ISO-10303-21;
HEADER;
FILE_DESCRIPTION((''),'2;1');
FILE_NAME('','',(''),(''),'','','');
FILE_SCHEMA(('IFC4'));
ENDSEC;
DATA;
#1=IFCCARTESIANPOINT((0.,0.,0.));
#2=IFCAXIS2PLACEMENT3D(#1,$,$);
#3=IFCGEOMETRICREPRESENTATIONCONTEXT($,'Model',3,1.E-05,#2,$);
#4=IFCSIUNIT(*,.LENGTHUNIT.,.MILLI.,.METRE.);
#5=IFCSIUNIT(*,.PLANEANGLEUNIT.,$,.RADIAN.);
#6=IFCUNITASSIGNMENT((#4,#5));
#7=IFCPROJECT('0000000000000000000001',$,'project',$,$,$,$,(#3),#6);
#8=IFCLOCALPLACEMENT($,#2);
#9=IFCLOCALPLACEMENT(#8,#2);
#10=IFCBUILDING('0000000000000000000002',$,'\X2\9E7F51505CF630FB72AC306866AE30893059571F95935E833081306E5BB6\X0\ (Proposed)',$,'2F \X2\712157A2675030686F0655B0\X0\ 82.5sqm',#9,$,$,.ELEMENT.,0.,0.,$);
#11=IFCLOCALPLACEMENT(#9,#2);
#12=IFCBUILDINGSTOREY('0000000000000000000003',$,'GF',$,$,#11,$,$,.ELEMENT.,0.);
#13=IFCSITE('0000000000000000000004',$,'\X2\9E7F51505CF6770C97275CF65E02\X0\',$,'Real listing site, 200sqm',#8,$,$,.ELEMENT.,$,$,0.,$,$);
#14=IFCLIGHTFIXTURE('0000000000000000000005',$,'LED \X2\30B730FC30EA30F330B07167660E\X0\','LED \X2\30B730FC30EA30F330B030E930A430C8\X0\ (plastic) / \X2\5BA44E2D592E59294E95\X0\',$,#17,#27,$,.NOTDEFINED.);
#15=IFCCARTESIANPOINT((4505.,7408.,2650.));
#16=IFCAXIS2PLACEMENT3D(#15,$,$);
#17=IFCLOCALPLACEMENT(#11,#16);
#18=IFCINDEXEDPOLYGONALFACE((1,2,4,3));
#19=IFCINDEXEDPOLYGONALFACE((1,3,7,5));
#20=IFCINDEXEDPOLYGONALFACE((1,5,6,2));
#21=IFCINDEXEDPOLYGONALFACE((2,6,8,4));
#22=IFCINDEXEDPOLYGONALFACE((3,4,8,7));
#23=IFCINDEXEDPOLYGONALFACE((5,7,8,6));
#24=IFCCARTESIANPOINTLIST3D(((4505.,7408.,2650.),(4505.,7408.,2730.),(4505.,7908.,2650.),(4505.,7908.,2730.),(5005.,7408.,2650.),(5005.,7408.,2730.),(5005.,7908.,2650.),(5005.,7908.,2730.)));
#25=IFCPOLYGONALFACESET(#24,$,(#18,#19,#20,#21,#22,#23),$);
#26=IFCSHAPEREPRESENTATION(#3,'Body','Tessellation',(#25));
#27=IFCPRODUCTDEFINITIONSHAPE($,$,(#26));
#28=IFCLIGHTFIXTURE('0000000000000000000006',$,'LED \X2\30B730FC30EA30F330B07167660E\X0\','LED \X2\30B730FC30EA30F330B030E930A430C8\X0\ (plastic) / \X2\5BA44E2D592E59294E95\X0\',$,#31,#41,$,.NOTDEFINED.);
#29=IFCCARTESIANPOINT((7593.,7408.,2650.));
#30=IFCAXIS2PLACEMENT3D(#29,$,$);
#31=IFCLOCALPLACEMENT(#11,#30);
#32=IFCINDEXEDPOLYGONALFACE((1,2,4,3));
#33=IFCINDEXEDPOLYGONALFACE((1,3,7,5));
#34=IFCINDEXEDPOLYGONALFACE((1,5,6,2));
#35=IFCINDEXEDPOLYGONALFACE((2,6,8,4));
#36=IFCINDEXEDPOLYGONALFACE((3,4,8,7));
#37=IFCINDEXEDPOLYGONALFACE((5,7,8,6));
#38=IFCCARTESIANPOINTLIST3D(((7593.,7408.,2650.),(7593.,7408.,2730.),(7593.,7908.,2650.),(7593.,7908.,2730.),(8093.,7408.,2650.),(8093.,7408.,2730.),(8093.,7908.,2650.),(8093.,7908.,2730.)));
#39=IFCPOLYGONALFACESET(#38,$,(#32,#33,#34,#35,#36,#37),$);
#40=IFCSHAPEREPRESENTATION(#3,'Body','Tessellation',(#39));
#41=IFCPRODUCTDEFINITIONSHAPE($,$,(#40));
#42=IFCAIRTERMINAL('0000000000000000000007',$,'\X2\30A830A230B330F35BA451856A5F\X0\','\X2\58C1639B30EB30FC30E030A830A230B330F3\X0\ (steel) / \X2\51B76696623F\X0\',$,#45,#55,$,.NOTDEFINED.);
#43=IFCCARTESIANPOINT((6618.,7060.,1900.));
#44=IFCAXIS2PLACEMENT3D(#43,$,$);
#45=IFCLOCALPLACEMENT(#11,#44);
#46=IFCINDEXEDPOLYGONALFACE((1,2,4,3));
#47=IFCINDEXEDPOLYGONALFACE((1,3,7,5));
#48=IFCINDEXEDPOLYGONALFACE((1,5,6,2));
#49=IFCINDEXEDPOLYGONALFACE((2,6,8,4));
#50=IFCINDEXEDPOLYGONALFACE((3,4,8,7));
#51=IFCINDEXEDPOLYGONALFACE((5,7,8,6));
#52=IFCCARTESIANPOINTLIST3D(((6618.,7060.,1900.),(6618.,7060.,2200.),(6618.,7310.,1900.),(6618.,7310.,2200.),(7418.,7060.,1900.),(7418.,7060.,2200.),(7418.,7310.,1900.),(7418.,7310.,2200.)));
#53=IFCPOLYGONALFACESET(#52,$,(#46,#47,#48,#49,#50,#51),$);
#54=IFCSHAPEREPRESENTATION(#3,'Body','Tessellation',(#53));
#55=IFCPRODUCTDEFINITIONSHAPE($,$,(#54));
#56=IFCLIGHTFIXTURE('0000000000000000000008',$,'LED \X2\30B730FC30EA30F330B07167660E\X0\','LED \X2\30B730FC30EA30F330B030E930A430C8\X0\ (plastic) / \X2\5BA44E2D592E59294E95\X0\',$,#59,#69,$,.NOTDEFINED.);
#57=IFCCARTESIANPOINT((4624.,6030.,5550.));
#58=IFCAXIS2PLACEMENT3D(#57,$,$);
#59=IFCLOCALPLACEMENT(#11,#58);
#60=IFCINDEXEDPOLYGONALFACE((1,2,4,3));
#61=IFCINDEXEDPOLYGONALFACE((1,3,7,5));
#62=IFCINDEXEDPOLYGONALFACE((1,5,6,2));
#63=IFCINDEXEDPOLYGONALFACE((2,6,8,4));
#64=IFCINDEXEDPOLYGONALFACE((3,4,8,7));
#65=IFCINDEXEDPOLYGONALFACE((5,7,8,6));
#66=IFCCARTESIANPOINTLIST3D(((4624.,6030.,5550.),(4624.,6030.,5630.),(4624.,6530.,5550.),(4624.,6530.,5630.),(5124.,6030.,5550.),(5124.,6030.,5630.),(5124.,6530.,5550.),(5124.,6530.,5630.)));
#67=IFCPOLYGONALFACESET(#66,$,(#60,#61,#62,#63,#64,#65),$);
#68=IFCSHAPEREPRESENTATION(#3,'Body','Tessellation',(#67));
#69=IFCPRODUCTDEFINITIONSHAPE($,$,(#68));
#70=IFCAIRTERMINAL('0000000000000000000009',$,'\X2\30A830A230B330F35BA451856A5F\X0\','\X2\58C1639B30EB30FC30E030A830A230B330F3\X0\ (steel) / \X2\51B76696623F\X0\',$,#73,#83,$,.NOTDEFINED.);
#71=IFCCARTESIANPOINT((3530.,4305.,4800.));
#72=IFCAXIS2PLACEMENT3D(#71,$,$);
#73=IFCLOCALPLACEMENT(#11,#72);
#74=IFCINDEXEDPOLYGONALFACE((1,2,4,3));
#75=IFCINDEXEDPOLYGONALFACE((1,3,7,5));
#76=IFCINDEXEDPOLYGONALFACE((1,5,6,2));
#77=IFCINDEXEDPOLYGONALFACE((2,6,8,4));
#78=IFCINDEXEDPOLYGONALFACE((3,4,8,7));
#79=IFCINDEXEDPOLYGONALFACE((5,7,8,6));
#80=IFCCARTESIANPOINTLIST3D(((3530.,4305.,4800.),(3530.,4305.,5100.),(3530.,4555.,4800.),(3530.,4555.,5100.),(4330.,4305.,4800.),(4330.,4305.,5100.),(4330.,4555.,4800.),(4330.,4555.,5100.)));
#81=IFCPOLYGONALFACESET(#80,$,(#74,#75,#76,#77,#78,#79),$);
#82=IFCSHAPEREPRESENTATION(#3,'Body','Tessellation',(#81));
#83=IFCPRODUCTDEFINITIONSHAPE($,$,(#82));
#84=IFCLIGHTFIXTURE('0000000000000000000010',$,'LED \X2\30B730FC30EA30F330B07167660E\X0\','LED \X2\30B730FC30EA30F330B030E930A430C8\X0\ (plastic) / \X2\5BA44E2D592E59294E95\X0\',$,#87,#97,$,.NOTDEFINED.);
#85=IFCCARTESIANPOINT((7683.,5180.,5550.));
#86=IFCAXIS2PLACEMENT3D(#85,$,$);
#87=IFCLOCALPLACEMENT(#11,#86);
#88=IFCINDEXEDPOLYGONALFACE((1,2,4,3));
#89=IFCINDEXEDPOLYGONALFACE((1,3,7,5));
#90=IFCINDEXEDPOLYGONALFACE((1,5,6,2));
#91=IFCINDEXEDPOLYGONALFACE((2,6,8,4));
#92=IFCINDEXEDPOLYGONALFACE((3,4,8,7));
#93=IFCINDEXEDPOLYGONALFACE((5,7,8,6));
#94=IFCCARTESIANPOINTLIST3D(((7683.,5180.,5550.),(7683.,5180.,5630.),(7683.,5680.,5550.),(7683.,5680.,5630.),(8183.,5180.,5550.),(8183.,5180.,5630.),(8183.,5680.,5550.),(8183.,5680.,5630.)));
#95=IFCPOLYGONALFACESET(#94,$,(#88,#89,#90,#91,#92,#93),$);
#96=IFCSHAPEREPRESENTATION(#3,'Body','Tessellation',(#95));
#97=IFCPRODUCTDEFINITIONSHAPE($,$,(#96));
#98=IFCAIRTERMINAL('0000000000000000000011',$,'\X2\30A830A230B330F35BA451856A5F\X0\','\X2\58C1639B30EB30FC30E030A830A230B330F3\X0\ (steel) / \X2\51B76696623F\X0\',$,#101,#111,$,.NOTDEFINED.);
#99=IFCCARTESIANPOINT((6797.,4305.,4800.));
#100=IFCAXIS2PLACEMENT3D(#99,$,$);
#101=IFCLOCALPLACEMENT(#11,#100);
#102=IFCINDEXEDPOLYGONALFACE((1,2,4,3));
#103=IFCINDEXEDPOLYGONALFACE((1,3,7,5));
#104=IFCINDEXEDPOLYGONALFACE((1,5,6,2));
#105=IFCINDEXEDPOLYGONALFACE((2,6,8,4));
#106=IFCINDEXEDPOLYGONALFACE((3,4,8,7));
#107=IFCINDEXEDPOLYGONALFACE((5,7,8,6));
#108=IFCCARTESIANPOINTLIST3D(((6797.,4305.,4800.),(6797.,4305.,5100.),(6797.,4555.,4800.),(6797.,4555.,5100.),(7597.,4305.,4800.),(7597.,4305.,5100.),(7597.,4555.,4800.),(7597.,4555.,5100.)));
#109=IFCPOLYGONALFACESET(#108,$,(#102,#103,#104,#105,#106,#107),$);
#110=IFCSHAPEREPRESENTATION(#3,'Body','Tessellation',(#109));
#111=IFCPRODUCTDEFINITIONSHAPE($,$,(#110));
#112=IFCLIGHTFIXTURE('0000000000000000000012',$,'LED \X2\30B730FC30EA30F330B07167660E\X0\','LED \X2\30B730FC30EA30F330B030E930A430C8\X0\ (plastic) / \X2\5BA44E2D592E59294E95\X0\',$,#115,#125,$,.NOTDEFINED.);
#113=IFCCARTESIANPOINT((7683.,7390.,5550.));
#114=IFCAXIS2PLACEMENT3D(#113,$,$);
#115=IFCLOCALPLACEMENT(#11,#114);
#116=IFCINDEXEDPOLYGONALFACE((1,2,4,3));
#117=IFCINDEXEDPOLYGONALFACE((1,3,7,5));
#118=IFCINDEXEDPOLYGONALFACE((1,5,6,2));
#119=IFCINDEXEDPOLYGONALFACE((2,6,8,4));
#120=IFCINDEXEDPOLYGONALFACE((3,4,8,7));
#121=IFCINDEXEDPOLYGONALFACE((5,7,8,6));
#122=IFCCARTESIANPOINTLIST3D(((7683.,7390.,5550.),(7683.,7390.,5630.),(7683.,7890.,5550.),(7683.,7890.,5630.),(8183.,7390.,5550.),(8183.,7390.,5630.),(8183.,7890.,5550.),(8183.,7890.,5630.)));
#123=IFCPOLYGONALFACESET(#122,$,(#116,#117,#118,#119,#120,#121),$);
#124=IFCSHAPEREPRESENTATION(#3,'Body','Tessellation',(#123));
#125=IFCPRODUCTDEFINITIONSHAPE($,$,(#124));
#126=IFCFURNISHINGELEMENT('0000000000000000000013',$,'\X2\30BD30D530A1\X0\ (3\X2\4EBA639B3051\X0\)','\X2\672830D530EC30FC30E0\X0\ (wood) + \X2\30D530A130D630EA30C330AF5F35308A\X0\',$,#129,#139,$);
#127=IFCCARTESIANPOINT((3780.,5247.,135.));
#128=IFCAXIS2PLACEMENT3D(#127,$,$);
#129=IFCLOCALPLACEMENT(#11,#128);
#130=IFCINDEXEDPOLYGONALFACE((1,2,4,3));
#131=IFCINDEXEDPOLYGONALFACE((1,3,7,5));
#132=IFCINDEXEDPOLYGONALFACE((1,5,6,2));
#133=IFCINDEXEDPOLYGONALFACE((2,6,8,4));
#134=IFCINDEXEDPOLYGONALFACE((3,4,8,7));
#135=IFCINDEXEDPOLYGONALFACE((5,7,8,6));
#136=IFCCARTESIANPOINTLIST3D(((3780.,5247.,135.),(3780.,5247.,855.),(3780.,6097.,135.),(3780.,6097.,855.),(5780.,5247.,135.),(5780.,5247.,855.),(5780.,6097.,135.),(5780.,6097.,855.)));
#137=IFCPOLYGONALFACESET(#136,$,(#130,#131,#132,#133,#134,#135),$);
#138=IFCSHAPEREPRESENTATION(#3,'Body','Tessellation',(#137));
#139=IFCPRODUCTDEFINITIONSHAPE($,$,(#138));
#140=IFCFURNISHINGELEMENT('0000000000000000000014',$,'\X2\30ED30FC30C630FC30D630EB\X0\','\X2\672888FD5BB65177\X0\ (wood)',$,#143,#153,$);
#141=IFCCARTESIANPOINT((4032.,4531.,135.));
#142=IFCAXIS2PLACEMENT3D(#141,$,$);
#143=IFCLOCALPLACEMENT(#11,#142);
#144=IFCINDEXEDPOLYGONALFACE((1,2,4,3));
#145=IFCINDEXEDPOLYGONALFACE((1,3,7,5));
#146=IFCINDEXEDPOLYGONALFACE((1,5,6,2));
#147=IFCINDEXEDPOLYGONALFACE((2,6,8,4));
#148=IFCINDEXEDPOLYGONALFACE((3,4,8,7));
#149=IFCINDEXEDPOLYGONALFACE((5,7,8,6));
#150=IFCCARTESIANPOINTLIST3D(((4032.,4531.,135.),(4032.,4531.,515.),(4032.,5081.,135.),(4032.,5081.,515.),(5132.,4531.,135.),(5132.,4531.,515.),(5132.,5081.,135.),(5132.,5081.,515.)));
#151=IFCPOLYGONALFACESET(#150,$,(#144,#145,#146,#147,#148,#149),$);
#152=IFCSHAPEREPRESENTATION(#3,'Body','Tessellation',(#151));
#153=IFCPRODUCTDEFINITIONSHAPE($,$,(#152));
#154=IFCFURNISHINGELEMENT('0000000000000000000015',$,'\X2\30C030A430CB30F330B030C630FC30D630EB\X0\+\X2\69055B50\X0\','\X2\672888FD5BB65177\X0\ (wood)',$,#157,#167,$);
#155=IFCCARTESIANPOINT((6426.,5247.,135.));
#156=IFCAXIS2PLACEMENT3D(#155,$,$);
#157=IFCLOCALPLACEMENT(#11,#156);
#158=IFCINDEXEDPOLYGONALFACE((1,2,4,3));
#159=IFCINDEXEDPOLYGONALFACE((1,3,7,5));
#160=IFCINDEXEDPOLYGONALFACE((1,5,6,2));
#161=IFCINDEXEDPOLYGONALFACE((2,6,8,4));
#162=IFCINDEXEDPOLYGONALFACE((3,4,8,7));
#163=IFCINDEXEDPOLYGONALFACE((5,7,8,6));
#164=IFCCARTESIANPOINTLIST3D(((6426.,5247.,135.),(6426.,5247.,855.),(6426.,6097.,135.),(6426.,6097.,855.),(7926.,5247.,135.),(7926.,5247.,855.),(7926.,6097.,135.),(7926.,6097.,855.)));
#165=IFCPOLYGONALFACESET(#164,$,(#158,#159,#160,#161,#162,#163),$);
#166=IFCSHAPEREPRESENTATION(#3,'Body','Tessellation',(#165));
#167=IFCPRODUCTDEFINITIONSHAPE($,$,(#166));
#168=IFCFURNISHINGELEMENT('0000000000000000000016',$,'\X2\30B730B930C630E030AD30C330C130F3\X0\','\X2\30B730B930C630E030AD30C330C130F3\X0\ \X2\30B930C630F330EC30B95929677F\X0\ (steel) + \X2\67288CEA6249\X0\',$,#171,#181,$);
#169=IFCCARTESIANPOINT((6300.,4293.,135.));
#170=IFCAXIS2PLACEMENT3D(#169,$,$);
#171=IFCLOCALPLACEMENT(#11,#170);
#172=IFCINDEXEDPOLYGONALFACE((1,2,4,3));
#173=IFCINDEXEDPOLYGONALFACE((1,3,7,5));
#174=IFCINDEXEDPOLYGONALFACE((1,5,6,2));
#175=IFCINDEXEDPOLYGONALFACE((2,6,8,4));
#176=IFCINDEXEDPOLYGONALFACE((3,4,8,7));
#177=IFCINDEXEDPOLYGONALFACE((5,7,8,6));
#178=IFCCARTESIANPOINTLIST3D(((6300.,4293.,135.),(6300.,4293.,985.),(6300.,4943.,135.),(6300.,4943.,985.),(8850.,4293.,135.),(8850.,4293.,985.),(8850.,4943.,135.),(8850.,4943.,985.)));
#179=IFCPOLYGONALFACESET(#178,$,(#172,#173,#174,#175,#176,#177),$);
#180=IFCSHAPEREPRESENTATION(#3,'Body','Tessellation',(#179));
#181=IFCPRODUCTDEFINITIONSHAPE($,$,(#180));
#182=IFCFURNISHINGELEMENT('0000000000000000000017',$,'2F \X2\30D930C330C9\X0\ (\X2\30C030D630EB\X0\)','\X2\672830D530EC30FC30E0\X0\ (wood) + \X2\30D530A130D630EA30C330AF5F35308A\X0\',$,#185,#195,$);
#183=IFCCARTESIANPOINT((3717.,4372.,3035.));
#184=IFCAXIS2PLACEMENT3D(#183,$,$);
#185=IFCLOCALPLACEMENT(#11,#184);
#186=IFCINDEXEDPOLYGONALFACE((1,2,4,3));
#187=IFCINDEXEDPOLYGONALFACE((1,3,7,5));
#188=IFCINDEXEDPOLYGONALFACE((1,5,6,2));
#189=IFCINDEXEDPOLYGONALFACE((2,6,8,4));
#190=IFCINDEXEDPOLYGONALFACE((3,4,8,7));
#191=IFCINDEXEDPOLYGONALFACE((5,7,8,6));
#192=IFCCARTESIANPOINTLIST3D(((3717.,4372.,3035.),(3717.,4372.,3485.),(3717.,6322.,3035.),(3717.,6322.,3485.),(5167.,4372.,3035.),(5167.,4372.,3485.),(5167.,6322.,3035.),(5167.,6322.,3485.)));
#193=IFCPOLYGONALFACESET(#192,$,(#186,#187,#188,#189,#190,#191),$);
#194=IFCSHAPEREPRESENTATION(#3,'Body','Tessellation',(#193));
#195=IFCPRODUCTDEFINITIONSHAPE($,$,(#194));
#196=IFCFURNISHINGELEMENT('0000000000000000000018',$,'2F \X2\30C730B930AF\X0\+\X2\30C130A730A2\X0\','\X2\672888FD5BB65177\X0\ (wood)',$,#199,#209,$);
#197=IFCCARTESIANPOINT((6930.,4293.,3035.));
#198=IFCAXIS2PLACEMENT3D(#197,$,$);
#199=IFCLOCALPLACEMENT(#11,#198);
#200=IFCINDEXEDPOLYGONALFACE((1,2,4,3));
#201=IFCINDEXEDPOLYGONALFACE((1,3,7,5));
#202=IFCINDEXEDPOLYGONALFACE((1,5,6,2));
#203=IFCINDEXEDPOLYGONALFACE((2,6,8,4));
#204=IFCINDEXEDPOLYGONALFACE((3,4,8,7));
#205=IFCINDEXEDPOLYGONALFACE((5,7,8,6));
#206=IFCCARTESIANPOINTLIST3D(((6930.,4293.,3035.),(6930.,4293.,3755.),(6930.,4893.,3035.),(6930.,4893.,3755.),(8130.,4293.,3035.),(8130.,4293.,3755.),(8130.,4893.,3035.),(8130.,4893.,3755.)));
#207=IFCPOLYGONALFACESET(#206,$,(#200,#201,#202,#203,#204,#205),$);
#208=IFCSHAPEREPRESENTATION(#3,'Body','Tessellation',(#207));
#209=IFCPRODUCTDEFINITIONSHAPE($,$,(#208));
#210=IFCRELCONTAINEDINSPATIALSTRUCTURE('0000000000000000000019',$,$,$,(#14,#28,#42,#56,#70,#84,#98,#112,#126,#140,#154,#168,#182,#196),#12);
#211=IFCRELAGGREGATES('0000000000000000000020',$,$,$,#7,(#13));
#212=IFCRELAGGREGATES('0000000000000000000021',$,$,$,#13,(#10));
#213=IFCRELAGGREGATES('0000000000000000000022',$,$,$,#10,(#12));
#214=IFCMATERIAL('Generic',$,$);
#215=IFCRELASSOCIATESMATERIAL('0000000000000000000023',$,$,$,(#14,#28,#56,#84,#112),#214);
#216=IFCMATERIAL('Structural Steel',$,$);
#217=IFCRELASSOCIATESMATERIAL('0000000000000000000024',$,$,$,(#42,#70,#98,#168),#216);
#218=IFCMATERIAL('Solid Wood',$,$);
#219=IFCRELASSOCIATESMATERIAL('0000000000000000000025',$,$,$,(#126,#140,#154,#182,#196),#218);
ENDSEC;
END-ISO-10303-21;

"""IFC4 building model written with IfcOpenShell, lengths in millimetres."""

from ifc_helpers import new_model, si_unit, frame, frame_2d, origin, place, context, project, spatial, rectangle, extrude, material, element, save


model = new_model("IFC4")

# Units and contexts
model_context = context("Model", 3, precision=1e-05, world=origin())
ifc_project = project(units=[si_unit("LENGTHUNIT", "METRE", prefix="MILLI"), si_unit("PLANEANGLEUNIT", "RADIAN")], contexts=[model_context])

# Site, building, storey
site_placement = place(None, origin())
site = spatial("IfcSite", under=ifc_project, at=site_placement, Name="鹿児島県霧島市", ObjectType="Real listing site, 200sqm", CompositionType="ELEMENT", RefElevation=0.0)
building_placement = place(site_placement, origin())
building = spatial("IfcBuilding", under=site, at=building_placement, Name="鹿児島・犬と暮らす土間広めの家 (Proposed)", ObjectType="2F 無垢材と漆喰 82.5sqm", CompositionType="ELEMENT", ElevationOfRefHeight=0.0, ElevationOfTerrain=0.0)
storey_placement = place(building_placement, origin())
storey = spatial("IfcBuildingStorey", under=building, at=storey_placement, Name="GF", CompositionType="ELEMENT", Elevation=0.0)

# Shared definitions
ifc_material_1 = material(Name="Solid Wood")

# Shared definitions
ifc_material_2 = material(Name="Structural Steel")

# Shared definitions
ifc_material_3 = material(Name="Generic")

# Light fixtures
light_fixture_1_placement = place(storey_placement, frame((4505.0, 7408.0, 2650.0)))
element("IfcLightFixture", 1, at=light_fixture_1_placement, inside=storey, material=ifc_material_3, Name="LED シーリング照明", Description="LED シーリングライト (plastic) / 室中央天井", PredefinedType="NOTDEFINED", context=model_context, shape_type="SweptSolid", body=[
    extrude(rectangle(XDim=500.0, YDim=500.0, at=frame_2d((250.0, 250.0))), frame((4505.0, 7408.0, 2650.0)), (0.0, 0.0, 1.0), 80.0),
])
light_fixture_2_placement = place(storey_placement, frame((7593.0, 7408.0, 2650.0)))
element("IfcLightFixture", 2, at=light_fixture_2_placement, inside=storey, material=ifc_material_3, Name="LED シーリング照明", Description="LED シーリングライト (plastic) / 室中央天井", PredefinedType="NOTDEFINED", context=model_context, shape_type="SweptSolid", body=[
    extrude(rectangle(XDim=500.0, YDim=500.0, at=frame_2d((250.0, 250.0))), frame((7593.0, 7408.0, 2650.0)), (0.0, 0.0, 1.0), 80.0),
])

# Air terminal
air_terminal_1_placement = place(storey_placement, frame((6618.0, 7060.0, 1900.0)))
element("IfcAirTerminal", 3, at=air_terminal_1_placement, inside=storey, material=ifc_material_2, Name="エアコン室内機", Description="壁掛ルームエアコン (steel) / 冷暖房", PredefinedType="NOTDEFINED", context=model_context, shape_type="SweptSolid", body=[
    extrude(rectangle(XDim=800.0, YDim=250.0, at=frame_2d((400.0, 125.0))), frame((6618.0, 7060.0, 1900.0)), (0.0, 0.0, 1.0), 300.0),
])

# Light fixture
light_fixture_3_placement = place(storey_placement, frame((4624.0, 6030.0, 5550.0)))
element("IfcLightFixture", 4, at=light_fixture_3_placement, inside=storey, material=ifc_material_3, Name="LED シーリング照明", Description="LED シーリングライト (plastic) / 室中央天井", PredefinedType="NOTDEFINED", context=model_context, shape_type="SweptSolid", body=[
    extrude(rectangle(XDim=500.0, YDim=500.0, at=frame_2d((250.0, 250.0))), frame((4624.0, 6030.0, 5550.0)), (0.0, 0.0, 1.0), 80.0),
])

# Air terminal
air_terminal_2_placement = place(storey_placement, frame((3530.0, 4305.0, 4800.0)))
element("IfcAirTerminal", 5, at=air_terminal_2_placement, inside=storey, material=ifc_material_2, Name="エアコン室内機", Description="壁掛ルームエアコン (steel) / 冷暖房", PredefinedType="NOTDEFINED", context=model_context, shape_type="SweptSolid", body=[
    extrude(rectangle(XDim=800.0, YDim=250.0, at=frame_2d((400.0, 125.0))), frame((3530.0, 4305.0, 4800.0)), (0.0, 0.0, 1.0), 300.0),
])

# Light fixture
light_fixture_4_placement = place(storey_placement, frame((7683.0, 5180.0, 5550.0)))
element("IfcLightFixture", 6, at=light_fixture_4_placement, inside=storey, material=ifc_material_3, Name="LED シーリング照明", Description="LED シーリングライト (plastic) / 室中央天井", PredefinedType="NOTDEFINED", context=model_context, shape_type="SweptSolid", body=[
    extrude(rectangle(XDim=500.0, YDim=500.0, at=frame_2d((250.0, 250.0))), frame((7683.0, 5180.0, 5550.0)), (0.0, 0.0, 1.0), 80.0),
])

# Air terminal
air_terminal_3_placement = place(storey_placement, frame((6797.0, 4305.0, 4800.0)))
element("IfcAirTerminal", 7, at=air_terminal_3_placement, inside=storey, material=ifc_material_2, Name="エアコン室内機", Description="壁掛ルームエアコン (steel) / 冷暖房", PredefinedType="NOTDEFINED", context=model_context, shape_type="SweptSolid", body=[
    extrude(rectangle(XDim=800.0, YDim=250.0, at=frame_2d((400.0, 125.0))), frame((6797.0, 4305.0, 4800.0)), (0.0, 0.0, 1.0), 300.0),
])

# Light fixture
light_fixture_5_placement = place(storey_placement, frame((7683.0, 7390.0, 5550.0)))
element("IfcLightFixture", 8, at=light_fixture_5_placement, inside=storey, material=ifc_material_3, Name="LED シーリング照明", Description="LED シーリングライト (plastic) / 室中央天井", PredefinedType="NOTDEFINED", context=model_context, shape_type="SweptSolid", body=[
    extrude(rectangle(XDim=500.0, YDim=500.0, at=frame_2d((250.0, 250.0))), frame((7683.0, 7390.0, 5550.0)), (0.0, 0.0, 1.0), 80.0),
])

# Furnishing elements
furnishing_1_placement = place(storey_placement, frame((3780.0, 5247.0, 135.0)))
element("IfcFurnishingElement", 9, at=furnishing_1_placement, inside=storey, material=ifc_material_1, Name="ソファ (3人掛け)", Description="木フレーム (wood) + ファブリック張り", context=model_context, shape_type="SweptSolid", body=[
    extrude(rectangle(XDim=2000.0, YDim=850.0, at=frame_2d((1000.0, 425.0))), frame((3780.0, 5247.0, 135.0)), (0.0, 0.0, 1.0), 720.0),
])
furnishing_2_placement = place(storey_placement, frame((4032.0, 4531.0, 135.0)))
element("IfcFurnishingElement", 10, at=furnishing_2_placement, inside=storey, material=ifc_material_1, Name="ローテーブル", Description="木製家具 (wood)", context=model_context, shape_type="SweptSolid", body=[
    extrude(rectangle(XDim=1100.0, YDim=550.0, at=frame_2d((550.0, 275.0))), frame((4032.0, 4531.0, 135.0)), (0.0, 0.0, 1.0), 380.0),
])
furnishing_3_placement = place(storey_placement, frame((6426.0, 5247.0, 135.0)))
element("IfcFurnishingElement", 11, at=furnishing_3_placement, inside=storey, material=ifc_material_1, Name="ダイニングテーブル+椅子", Description="木製家具 (wood)", context=model_context, shape_type="SweptSolid", body=[
    extrude(rectangle(XDim=1500.0, YDim=850.0, at=frame_2d((750.0, 425.0))), frame((6426.0, 5247.0, 135.0)), (0.0, 0.0, 1.0), 720.0),
])
furnishing_4_placement = place(storey_placement, frame((6300.0, 4293.0, 135.0)))
element("IfcFurnishingElement", 12, at=furnishing_4_placement, inside=storey, material=ifc_material_2, Name="システムキッチン", Description="システムキッチン ステンレス天板 (steel) + 木質扉", context=model_context, shape_type="SweptSolid", body=[
    extrude(rectangle(XDim=2550.0, YDim=650.0, at=frame_2d((1275.0, 325.0))), frame((6300.0, 4293.0, 135.0)), (0.0, 0.0, 1.0), 850.0),
])
furnishing_5_placement = place(storey_placement, frame((3717.0, 4372.0, 3035.0)))
element("IfcFurnishingElement", 13, at=furnishing_5_placement, inside=storey, material=ifc_material_1, Name="2F ベッド (ダブル)", Description="木フレーム (wood) + ファブリック張り", context=model_context, shape_type="SweptSolid", body=[
    extrude(rectangle(XDim=1450.0, YDim=1950.0, at=frame_2d((725.0, 975.0))), frame((3717.0, 4372.0, 3035.0)), (0.0, 0.0, 1.0), 450.0),
])
furnishing_6_placement = place(storey_placement, frame((6930.0, 4293.0, 3035.0)))
element("IfcFurnishingElement", 14, at=furnishing_6_placement, inside=storey, material=ifc_material_1, Name="2F デスク+チェア", Description="木製家具 (wood)", context=model_context, shape_type="SweptSolid", body=[
    extrude(rectangle(XDim=1200.0, YDim=600.0, at=frame_2d((600.0, 300.0))), frame((6930.0, 4293.0, 3035.0)), (0.0, 0.0, 1.0), 720.0),
])

save(model, "model.ifc")
